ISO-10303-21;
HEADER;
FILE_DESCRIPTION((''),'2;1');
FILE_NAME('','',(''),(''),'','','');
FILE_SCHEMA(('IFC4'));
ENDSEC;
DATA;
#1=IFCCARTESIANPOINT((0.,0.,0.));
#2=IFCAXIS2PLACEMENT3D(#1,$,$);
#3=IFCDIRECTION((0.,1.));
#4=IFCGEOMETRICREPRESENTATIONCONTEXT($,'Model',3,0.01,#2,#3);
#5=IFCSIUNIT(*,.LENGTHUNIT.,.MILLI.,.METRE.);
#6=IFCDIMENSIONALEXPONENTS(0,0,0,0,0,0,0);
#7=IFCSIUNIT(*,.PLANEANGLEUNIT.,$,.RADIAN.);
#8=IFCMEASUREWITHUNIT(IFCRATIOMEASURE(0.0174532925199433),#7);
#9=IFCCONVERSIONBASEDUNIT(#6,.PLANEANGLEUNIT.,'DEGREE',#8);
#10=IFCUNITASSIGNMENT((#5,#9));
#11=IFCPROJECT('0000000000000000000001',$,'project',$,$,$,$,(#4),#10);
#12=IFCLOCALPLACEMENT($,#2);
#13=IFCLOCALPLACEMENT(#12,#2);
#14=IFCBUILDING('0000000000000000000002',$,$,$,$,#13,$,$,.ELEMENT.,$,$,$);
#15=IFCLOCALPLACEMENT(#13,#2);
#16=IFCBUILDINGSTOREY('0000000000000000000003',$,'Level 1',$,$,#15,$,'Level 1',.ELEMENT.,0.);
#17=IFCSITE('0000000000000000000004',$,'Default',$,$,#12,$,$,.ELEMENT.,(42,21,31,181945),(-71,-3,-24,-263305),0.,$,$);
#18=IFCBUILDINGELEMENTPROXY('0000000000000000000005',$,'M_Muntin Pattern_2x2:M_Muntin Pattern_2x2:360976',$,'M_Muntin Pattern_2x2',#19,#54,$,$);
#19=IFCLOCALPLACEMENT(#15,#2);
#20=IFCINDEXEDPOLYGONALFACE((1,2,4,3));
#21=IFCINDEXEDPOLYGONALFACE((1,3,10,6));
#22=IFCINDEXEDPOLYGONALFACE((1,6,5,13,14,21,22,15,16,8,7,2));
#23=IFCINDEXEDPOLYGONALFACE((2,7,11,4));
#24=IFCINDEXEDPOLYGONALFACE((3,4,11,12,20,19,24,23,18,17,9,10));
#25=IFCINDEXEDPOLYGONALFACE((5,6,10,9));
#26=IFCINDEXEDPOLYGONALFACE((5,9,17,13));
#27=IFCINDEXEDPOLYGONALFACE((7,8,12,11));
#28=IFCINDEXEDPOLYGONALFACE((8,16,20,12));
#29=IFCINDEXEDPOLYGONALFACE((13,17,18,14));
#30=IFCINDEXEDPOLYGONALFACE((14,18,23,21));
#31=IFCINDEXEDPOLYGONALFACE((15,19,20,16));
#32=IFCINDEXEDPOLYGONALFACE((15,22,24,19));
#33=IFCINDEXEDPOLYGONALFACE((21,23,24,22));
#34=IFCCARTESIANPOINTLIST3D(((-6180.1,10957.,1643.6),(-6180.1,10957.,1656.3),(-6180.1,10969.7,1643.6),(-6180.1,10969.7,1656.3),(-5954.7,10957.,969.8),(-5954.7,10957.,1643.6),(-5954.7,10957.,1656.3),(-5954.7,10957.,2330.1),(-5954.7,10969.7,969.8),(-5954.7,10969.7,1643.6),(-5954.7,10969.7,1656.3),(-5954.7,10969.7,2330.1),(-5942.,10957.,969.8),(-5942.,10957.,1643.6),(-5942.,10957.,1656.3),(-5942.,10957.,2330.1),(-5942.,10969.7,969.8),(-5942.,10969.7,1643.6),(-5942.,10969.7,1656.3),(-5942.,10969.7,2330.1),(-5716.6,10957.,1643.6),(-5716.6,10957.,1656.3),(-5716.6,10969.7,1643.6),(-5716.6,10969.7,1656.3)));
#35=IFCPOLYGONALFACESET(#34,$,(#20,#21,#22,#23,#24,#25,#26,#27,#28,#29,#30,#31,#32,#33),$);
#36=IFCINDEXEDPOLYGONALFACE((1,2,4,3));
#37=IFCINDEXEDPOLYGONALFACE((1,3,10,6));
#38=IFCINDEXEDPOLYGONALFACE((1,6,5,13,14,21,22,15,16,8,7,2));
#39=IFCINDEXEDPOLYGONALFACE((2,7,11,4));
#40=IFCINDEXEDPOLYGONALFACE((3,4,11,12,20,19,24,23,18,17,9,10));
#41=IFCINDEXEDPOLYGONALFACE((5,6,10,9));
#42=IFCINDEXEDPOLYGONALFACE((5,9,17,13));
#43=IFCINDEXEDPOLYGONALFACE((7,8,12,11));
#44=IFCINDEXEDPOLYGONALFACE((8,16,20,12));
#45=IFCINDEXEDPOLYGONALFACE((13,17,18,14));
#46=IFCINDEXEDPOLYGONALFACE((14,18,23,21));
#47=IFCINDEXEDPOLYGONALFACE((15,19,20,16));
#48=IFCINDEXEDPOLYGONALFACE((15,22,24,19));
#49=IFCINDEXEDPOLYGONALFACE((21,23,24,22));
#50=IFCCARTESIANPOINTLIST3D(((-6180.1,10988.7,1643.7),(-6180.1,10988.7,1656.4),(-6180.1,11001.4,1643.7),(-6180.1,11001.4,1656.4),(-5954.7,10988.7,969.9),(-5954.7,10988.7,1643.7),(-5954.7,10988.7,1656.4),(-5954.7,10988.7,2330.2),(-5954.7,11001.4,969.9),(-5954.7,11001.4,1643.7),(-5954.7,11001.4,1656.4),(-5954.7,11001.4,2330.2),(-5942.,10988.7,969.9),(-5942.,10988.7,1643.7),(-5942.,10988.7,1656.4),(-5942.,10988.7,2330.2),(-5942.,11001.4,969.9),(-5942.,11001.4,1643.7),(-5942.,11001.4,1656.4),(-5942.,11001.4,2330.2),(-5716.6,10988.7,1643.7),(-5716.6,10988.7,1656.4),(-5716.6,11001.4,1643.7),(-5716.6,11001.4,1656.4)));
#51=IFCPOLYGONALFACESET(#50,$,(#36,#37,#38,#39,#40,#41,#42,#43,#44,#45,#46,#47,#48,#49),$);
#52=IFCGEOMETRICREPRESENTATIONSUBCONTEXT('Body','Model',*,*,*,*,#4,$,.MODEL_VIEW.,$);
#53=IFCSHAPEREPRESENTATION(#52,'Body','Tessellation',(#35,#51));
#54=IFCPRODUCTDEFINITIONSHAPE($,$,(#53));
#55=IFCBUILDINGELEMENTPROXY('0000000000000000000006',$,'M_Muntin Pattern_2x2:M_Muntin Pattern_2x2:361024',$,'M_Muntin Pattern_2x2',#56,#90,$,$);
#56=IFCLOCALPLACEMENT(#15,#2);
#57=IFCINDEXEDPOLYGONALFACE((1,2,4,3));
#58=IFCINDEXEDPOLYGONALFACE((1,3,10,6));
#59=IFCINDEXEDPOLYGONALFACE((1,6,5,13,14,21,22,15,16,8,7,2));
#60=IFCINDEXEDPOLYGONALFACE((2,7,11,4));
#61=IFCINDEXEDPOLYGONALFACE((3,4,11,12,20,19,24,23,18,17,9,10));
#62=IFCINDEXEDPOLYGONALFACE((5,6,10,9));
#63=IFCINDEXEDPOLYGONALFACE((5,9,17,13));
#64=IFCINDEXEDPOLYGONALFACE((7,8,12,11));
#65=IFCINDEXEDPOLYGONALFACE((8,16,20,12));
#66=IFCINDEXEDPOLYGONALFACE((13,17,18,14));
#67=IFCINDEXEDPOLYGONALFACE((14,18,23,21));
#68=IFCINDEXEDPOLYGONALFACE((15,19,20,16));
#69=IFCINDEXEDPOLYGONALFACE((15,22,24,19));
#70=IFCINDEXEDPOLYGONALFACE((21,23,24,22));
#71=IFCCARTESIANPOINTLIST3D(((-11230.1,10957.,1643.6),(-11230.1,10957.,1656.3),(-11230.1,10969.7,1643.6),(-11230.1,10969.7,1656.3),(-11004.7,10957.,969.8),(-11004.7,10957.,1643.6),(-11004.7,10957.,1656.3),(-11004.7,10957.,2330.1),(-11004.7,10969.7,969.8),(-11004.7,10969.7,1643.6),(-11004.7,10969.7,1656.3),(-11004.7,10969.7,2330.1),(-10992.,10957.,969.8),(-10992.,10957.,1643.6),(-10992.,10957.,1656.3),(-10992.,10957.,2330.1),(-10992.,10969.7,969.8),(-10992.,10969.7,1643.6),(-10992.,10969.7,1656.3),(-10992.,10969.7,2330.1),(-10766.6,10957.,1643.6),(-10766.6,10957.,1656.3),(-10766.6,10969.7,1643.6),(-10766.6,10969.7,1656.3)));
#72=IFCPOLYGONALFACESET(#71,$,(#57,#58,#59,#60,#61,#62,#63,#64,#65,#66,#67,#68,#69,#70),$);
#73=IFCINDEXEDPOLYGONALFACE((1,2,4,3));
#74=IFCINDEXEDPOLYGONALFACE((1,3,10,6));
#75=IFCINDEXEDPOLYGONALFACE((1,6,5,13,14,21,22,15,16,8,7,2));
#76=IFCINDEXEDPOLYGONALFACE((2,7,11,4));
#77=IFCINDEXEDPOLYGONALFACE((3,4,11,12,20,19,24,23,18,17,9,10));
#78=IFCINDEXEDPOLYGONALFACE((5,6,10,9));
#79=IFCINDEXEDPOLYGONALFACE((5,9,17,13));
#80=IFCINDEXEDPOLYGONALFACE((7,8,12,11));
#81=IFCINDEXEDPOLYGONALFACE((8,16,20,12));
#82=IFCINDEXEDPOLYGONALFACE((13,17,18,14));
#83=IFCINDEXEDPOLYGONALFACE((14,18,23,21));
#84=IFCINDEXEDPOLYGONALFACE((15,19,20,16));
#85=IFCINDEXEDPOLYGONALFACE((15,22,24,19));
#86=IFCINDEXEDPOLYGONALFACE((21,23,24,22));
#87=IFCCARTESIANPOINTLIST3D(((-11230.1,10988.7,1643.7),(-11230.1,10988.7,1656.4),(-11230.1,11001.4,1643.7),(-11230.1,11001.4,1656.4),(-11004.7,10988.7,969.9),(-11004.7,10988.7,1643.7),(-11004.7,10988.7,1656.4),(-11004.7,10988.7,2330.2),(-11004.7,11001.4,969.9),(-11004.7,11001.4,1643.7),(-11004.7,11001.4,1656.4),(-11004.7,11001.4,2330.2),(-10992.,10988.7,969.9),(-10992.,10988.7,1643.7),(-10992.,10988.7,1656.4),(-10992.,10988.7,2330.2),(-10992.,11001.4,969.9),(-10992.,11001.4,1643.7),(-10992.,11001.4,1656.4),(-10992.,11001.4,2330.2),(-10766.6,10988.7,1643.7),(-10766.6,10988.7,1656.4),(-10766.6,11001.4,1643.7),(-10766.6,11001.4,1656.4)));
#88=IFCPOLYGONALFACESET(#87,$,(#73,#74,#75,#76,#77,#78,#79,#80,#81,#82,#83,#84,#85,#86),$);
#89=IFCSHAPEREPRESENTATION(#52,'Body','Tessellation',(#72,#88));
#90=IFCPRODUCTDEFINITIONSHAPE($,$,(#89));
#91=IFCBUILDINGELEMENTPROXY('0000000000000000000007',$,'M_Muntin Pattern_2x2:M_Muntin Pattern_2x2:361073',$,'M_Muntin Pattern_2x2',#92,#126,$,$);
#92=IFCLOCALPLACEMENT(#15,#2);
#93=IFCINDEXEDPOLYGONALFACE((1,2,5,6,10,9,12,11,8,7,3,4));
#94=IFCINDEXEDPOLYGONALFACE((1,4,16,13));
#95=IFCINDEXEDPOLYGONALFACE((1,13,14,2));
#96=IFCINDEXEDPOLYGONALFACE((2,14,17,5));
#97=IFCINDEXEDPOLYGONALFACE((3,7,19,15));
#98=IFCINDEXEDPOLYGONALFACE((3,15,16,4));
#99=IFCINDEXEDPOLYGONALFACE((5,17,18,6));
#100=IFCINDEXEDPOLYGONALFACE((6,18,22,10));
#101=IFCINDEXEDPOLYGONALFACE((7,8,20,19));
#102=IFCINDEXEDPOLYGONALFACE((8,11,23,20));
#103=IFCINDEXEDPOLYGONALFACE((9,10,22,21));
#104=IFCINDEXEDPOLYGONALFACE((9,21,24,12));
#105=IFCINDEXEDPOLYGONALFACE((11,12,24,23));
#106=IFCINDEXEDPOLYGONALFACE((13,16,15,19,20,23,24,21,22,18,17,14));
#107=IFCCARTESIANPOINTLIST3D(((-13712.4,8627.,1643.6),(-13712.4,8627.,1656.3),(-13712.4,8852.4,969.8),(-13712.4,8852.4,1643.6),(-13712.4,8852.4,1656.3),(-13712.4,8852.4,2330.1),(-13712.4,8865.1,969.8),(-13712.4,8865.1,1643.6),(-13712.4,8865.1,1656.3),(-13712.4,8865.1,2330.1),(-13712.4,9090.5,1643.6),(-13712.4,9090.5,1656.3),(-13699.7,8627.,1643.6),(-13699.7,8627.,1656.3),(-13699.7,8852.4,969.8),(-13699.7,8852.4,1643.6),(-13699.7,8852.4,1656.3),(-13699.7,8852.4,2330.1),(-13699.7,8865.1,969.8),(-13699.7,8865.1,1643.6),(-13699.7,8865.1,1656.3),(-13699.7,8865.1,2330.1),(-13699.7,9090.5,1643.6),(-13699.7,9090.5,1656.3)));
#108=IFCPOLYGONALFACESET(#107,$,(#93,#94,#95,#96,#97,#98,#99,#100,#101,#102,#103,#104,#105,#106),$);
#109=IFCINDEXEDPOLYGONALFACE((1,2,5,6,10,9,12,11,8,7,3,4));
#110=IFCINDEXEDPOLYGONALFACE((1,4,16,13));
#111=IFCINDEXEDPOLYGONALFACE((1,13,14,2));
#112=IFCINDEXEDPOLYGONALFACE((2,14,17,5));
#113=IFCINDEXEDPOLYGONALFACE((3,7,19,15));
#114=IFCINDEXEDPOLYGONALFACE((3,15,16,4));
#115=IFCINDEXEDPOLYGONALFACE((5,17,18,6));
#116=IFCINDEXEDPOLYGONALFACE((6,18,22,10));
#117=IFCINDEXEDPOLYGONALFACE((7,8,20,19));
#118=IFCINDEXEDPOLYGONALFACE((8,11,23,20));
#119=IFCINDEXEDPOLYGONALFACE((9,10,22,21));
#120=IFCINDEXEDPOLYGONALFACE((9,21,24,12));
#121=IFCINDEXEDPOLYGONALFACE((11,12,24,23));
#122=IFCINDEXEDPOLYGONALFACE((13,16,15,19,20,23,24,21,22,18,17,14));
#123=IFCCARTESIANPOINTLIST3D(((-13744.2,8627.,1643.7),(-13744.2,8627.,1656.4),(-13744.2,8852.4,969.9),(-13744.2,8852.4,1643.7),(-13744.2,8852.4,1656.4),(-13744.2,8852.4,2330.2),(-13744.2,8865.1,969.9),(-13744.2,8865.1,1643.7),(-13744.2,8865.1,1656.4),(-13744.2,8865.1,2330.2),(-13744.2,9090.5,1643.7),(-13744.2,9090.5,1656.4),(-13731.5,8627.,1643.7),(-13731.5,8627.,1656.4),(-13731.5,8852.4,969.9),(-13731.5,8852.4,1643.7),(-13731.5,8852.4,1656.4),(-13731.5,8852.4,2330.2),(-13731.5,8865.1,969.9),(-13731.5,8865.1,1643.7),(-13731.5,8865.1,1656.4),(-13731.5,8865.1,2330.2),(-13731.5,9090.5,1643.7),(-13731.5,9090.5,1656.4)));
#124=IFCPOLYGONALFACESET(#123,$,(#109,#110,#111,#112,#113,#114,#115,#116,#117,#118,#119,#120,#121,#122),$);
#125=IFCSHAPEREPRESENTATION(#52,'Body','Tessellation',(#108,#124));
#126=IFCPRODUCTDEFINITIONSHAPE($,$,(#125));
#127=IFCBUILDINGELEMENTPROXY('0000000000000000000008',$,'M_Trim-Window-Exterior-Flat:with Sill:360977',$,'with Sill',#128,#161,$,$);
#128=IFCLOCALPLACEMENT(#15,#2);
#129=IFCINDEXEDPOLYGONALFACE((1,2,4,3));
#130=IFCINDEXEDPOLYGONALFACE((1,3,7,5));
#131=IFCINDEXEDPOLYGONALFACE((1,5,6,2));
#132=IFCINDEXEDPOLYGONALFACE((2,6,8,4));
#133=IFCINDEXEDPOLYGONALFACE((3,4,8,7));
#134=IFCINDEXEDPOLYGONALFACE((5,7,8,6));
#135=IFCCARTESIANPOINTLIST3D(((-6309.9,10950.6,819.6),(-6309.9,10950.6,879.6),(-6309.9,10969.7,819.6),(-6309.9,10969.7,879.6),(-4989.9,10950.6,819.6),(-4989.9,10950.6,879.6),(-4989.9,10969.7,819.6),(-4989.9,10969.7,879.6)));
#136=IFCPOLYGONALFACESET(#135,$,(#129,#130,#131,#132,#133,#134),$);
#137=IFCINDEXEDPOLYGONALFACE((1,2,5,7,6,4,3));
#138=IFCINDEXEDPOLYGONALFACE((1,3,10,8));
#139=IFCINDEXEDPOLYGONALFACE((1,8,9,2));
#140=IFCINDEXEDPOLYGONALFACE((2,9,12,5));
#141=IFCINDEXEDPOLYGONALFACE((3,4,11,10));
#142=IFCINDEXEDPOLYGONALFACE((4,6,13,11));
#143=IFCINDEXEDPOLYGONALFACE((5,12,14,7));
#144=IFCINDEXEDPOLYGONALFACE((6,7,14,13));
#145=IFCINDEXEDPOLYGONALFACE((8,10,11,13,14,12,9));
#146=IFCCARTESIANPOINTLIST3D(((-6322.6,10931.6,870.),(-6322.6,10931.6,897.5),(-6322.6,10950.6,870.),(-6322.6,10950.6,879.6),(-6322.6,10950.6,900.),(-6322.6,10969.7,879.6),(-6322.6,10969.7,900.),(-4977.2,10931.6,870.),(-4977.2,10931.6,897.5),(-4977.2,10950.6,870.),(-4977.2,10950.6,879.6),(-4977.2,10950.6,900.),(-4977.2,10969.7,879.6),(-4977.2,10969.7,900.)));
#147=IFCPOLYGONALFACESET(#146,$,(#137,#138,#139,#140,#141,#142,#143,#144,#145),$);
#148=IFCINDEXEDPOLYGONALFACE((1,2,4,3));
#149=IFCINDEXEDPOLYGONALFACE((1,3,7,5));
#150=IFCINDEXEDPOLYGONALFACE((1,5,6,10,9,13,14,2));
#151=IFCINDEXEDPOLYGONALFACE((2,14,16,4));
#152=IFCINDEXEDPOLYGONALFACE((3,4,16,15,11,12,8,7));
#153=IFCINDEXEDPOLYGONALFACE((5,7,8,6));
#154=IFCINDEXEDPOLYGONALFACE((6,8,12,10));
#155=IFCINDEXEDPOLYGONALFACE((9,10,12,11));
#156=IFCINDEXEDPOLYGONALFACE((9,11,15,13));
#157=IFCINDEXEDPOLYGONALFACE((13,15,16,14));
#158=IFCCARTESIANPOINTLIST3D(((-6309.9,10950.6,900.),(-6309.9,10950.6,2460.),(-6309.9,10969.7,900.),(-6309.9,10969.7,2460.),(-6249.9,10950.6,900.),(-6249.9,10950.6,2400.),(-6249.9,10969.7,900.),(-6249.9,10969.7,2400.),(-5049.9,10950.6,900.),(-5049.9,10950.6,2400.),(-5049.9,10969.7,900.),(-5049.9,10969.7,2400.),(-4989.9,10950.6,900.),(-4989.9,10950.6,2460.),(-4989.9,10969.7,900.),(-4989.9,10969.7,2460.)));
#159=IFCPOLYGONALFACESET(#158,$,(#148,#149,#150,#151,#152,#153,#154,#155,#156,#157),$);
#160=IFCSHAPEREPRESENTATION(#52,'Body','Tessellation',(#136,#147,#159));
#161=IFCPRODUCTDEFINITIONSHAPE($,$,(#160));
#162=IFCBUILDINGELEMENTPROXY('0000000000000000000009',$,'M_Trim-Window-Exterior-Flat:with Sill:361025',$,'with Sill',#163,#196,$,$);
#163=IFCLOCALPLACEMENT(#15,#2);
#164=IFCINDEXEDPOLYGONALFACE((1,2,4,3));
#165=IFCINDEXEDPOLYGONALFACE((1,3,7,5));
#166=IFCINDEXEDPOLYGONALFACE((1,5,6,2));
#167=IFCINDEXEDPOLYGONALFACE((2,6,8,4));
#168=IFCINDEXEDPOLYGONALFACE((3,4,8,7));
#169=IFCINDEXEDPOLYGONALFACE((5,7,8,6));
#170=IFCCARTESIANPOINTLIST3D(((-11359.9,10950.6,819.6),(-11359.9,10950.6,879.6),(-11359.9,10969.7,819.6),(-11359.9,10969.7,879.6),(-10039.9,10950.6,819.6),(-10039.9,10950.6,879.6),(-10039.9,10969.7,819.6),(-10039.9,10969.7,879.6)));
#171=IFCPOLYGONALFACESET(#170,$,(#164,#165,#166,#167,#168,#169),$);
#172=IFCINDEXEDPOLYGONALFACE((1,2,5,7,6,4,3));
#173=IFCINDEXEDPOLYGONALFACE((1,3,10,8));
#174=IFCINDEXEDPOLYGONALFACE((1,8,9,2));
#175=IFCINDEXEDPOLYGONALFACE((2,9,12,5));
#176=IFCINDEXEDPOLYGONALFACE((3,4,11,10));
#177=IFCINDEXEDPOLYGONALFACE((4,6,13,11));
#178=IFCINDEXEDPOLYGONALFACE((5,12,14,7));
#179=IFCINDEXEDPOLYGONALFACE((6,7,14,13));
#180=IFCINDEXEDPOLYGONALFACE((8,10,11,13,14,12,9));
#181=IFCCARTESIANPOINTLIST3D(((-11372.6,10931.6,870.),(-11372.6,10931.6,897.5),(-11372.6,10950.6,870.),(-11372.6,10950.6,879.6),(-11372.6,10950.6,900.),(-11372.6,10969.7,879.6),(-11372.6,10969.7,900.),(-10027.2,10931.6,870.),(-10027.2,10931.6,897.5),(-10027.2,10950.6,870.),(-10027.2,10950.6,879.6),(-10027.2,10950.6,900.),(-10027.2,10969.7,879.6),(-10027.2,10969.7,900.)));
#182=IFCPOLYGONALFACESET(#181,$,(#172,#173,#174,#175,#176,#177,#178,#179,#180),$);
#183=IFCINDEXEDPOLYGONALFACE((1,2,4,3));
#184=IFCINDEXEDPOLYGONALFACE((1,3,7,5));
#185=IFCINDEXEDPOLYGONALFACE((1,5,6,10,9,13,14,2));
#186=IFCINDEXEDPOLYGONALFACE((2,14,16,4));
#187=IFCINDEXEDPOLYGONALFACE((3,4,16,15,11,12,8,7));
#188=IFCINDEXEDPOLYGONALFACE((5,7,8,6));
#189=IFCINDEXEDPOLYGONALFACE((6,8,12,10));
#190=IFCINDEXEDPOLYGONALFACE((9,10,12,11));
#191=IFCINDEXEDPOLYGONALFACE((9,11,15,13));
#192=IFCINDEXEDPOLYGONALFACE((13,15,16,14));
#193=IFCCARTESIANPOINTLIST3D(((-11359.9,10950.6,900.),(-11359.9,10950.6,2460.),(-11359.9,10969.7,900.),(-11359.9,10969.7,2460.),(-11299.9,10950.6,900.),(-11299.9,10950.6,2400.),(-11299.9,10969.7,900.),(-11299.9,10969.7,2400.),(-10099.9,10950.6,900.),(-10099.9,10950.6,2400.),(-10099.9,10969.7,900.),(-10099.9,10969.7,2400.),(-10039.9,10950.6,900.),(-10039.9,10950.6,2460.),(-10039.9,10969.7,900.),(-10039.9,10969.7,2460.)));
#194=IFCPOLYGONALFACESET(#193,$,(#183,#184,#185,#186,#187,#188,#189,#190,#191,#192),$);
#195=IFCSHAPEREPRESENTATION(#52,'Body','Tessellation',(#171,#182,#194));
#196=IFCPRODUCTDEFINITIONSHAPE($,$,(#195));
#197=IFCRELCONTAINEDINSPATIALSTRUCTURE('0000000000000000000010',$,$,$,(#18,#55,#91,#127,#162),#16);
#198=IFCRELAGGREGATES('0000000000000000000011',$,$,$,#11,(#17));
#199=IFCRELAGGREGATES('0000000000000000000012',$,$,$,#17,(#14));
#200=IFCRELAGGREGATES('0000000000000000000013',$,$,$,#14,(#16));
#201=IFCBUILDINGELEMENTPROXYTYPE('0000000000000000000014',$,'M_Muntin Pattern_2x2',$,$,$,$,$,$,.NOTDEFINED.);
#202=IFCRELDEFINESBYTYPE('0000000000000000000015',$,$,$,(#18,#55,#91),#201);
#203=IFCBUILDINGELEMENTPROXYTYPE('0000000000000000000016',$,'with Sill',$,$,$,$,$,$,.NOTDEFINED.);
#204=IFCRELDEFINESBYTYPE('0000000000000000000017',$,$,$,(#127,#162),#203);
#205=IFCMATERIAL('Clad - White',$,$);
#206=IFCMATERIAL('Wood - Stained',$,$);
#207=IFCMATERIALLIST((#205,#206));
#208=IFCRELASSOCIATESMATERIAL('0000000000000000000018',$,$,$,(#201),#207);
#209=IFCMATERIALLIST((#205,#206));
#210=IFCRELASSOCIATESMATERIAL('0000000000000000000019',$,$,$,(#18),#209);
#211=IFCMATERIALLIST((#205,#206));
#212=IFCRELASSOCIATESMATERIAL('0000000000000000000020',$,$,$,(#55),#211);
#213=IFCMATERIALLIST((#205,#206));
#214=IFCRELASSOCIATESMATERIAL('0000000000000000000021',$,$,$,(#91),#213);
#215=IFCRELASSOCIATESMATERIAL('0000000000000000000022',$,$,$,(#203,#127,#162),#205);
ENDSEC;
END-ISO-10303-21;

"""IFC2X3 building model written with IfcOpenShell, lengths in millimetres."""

from ifc_helpers import new_model, entity, si_unit, converted_unit, direction, frame, frame_2d, origin, place, context, subcontext, project, spatial, polyline, rectangle, outline, extrude, source, transform, mapped, material, material_list, type_object, type_shapes, element, save


model = new_model("IFC2X3")

# Units and contexts
model_context = context("Model", 3, precision=0.01, world=origin(), true_north=direction((0.0, 1.0)))
body_context = subcontext(model_context, "Body", "Model", "MODEL_VIEW")
ifc_project = project(units=[si_unit("LENGTHUNIT", "METRE", prefix="MILLI"), converted_unit("PLANEANGLEUNIT", "DEGREE", entity("IfcRatioMeasure", 0.0174532925199433), si_unit("PLANEANGLEUNIT", "RADIAN"), dimensions=[0, 0, 0, 0, 0, 0, 0])], contexts=[model_context])

# Site, building, storey
site_placement = place(None, origin())
site = spatial("IfcSite", under=ifc_project, at=site_placement, Name="Default", CompositionType="ELEMENT", RefLatitude=(42, 21, 31, 181945), RefLongitude=(-71, -3, -24, -263305), RefElevation=0.0)
building_placement = place(site_placement, origin())
building = spatial("IfcBuilding", under=site, at=building_placement, CompositionType="ELEMENT")
storey_placement = place(building_placement, origin())
storey = spatial("IfcBuildingStorey", under=building, at=storey_placement, Name="Level 1", LongName="Level 1", CompositionType="ELEMENT", Elevation=0.0)

# Building element proxies
ifc_material_1 = material(Name="Clad - White")
ifc_material_2 = material(Name="Wood - Stained")
ifc_material_list_1 = material_list([ifc_material_1, ifc_material_2])
ifc_material_list_2 = material_list([ifc_material_1, ifc_material_2])
building_element_proxy_type_1 = type_object("IfcBuildingElementProxyType", Name="M_Muntin Pattern_2x2", PredefinedType="NOTDEFINED", material=ifc_material_list_2)
shared_shape_1 = source(origin(), body_context, "Body", "SweptSolid", [
    extrude(outline(polyline([(6.4, -6.4), (680.1, -6.4), (680.1, 6.3), (6.4, 6.3), (6.4, 231.7), (-6.3, 231.7), (-6.3, 6.3), (-680.2, 6.3), (-680.2, -6.4), (-6.3, -6.4), (-6.3, -231.7), (6.4, -231.7), (6.4, -6.4)])), frame((0.0, -22.2, 680.1), z_axis=(0.0, 1.0, 0.0), x_axis=(0.0, 0.0, 1.0)), (0.0, 0.0, 1.0), 12.7),
    extrude(outline(polyline([(6.4, -6.4), (680.1, -6.4), (680.1, 6.3), (6.4, 6.3), (6.4, 231.7), (-6.3, 231.7), (-6.3, 6.3), (-680.2, 6.3), (-680.2, -6.4), (-6.3, -6.4), (-6.3, -231.7), (6.4, -231.7), (6.4, -6.4)])), frame((0.0, 9.5, 680.2), z_axis=(0.0, 1.0, 0.0), x_axis=(0.0, 0.0, 1.0)), (0.0, 0.0, 1.0), 12.7),
])
type_shapes(building_element_proxy_type_1, [shared_shape_1])
proxy_1_placement = place(storey_placement, frame((-5948.4, 10979.2, 969.9)))
element("IfcBuildingElementProxy", 1, at=proxy_1_placement, inside=storey, type_object=building_element_proxy_type_1, material=ifc_material_list_1, Name="M_Muntin Pattern_2x2:M_Muntin Pattern_2x2:360976", ObjectType="M_Muntin Pattern_2x2", context=body_context, shape_type="MappedRepresentation", body=[
    mapped(shared_shape_1, transform((0.0, 0.0, 0.0), scale=1.0)),
])
ifc_material_list_3 = material_list([ifc_material_1, ifc_material_2])
proxy_2_placement = place(storey_placement, frame((-10998.4, 10979.2, 969.9)))
element("IfcBuildingElementProxy", 2, at=proxy_2_placement, inside=storey, type_object=building_element_proxy_type_1, material=ifc_material_list_3, Name="M_Muntin Pattern_2x2:M_Muntin Pattern_2x2:361024", ObjectType="M_Muntin Pattern_2x2", context=body_context, shape_type="MappedRepresentation", body=[
    mapped(shared_shape_1, transform((0.0, 0.0, 0.0), scale=1.0)),
])
ifc_material_list_4 = material_list([ifc_material_1, ifc_material_2])
proxy_3_placement = place(storey_placement, frame((-13722.0, 8858.7, 969.9), z_axis=(0.0, 0.0, 1.0), x_axis=(0.0, 1.0, 0.0)))
element("IfcBuildingElementProxy", 3, at=proxy_3_placement, inside=storey, type_object=building_element_proxy_type_1, material=ifc_material_list_4, Name="M_Muntin Pattern_2x2:M_Muntin Pattern_2x2:361073", ObjectType="M_Muntin Pattern_2x2", context=body_context, shape_type="MappedRepresentation", body=[
    mapped(shared_shape_1, transform((0.0, 0.0, 0.0), scale=1.0)),
])
building_element_proxy_type_2 = type_object("IfcBuildingElementProxyType", Name="with Sill", PredefinedType="NOTDEFINED", material=ifc_material_1)
shared_shape_2 = source(origin(), body_context, "Body", "SweptSolid", [
    extrude(rectangle(XDim=1320.0, YDim=60.0, at=frame_2d((0.0, 0.0), x_axis=(1.0, 0.0))), frame((0.0, -1550.4, 0.0), z_axis=(0.0, 0.0, 1.0), x_axis=(-1.0, 0.0, 0.0)), (0.0, 0.0, 1.0), 19.1),
    extrude(outline(polyline([(-19.0, -15.2), (0.0, -15.2), (0.0, -5.7), (19.0, -5.7), (19.0, 14.8), (0.0, 14.8), (-19.0, 12.3), (-19.0, -15.2)])), frame((-672.7, -1514.8, 19.0), z_axis=(1.0, 0.0, 0.0), x_axis=(0.0, 0.0, -1.0)), (0.0, 0.0, 1.0), 1345.4),
    extrude(outline(polyline([(-795.0, -660.0), (765.0, -660.0), (765.0, -600.0), (-735.0, -600.0), (-735.0, 600.0), (765.0, 600.0), (765.0, 660.0), (-795.0, 660.0), (-795.0, -660.0)])), frame((0.0, -735.0, 0.0), z_axis=(0.0, 0.0, 1.0), x_axis=(0.0, -1.0, 0.0)), (0.0, 0.0, 1.0), 19.1),
])
type_shapes(building_element_proxy_type_2, [shared_shape_2])
for number, where, z_axis, x_axis, name in (
    (4, (-5649.9, 10969.7, 2400.0), (0.0, -1.0, 0.0), (1.0, 0.0, 0.0), "M_Trim-Window-Exterior-Flat:with Sill:360977"),
    (5, (-10699.9, 10969.7, 2400.0), (0.0, -1.0, 0.0), (1.0, 0.0, 0.0), "M_Trim-Window-Exterior-Flat:with Sill:361025"),
):
    element("IfcBuildingElementProxy", number, at=place(storey_placement, frame(where, z_axis=z_axis, x_axis=x_axis)), inside=storey, type_object=building_element_proxy_type_2, material=ifc_material_1, Name=name, ObjectType="with Sill", context=body_context, shape_type="MappedRepresentation", body=[
        mapped(shared_shape_2, transform((0.0, 0.0, 0.0), scale=1.0)),
    ])

save(model, "model.ifc")
